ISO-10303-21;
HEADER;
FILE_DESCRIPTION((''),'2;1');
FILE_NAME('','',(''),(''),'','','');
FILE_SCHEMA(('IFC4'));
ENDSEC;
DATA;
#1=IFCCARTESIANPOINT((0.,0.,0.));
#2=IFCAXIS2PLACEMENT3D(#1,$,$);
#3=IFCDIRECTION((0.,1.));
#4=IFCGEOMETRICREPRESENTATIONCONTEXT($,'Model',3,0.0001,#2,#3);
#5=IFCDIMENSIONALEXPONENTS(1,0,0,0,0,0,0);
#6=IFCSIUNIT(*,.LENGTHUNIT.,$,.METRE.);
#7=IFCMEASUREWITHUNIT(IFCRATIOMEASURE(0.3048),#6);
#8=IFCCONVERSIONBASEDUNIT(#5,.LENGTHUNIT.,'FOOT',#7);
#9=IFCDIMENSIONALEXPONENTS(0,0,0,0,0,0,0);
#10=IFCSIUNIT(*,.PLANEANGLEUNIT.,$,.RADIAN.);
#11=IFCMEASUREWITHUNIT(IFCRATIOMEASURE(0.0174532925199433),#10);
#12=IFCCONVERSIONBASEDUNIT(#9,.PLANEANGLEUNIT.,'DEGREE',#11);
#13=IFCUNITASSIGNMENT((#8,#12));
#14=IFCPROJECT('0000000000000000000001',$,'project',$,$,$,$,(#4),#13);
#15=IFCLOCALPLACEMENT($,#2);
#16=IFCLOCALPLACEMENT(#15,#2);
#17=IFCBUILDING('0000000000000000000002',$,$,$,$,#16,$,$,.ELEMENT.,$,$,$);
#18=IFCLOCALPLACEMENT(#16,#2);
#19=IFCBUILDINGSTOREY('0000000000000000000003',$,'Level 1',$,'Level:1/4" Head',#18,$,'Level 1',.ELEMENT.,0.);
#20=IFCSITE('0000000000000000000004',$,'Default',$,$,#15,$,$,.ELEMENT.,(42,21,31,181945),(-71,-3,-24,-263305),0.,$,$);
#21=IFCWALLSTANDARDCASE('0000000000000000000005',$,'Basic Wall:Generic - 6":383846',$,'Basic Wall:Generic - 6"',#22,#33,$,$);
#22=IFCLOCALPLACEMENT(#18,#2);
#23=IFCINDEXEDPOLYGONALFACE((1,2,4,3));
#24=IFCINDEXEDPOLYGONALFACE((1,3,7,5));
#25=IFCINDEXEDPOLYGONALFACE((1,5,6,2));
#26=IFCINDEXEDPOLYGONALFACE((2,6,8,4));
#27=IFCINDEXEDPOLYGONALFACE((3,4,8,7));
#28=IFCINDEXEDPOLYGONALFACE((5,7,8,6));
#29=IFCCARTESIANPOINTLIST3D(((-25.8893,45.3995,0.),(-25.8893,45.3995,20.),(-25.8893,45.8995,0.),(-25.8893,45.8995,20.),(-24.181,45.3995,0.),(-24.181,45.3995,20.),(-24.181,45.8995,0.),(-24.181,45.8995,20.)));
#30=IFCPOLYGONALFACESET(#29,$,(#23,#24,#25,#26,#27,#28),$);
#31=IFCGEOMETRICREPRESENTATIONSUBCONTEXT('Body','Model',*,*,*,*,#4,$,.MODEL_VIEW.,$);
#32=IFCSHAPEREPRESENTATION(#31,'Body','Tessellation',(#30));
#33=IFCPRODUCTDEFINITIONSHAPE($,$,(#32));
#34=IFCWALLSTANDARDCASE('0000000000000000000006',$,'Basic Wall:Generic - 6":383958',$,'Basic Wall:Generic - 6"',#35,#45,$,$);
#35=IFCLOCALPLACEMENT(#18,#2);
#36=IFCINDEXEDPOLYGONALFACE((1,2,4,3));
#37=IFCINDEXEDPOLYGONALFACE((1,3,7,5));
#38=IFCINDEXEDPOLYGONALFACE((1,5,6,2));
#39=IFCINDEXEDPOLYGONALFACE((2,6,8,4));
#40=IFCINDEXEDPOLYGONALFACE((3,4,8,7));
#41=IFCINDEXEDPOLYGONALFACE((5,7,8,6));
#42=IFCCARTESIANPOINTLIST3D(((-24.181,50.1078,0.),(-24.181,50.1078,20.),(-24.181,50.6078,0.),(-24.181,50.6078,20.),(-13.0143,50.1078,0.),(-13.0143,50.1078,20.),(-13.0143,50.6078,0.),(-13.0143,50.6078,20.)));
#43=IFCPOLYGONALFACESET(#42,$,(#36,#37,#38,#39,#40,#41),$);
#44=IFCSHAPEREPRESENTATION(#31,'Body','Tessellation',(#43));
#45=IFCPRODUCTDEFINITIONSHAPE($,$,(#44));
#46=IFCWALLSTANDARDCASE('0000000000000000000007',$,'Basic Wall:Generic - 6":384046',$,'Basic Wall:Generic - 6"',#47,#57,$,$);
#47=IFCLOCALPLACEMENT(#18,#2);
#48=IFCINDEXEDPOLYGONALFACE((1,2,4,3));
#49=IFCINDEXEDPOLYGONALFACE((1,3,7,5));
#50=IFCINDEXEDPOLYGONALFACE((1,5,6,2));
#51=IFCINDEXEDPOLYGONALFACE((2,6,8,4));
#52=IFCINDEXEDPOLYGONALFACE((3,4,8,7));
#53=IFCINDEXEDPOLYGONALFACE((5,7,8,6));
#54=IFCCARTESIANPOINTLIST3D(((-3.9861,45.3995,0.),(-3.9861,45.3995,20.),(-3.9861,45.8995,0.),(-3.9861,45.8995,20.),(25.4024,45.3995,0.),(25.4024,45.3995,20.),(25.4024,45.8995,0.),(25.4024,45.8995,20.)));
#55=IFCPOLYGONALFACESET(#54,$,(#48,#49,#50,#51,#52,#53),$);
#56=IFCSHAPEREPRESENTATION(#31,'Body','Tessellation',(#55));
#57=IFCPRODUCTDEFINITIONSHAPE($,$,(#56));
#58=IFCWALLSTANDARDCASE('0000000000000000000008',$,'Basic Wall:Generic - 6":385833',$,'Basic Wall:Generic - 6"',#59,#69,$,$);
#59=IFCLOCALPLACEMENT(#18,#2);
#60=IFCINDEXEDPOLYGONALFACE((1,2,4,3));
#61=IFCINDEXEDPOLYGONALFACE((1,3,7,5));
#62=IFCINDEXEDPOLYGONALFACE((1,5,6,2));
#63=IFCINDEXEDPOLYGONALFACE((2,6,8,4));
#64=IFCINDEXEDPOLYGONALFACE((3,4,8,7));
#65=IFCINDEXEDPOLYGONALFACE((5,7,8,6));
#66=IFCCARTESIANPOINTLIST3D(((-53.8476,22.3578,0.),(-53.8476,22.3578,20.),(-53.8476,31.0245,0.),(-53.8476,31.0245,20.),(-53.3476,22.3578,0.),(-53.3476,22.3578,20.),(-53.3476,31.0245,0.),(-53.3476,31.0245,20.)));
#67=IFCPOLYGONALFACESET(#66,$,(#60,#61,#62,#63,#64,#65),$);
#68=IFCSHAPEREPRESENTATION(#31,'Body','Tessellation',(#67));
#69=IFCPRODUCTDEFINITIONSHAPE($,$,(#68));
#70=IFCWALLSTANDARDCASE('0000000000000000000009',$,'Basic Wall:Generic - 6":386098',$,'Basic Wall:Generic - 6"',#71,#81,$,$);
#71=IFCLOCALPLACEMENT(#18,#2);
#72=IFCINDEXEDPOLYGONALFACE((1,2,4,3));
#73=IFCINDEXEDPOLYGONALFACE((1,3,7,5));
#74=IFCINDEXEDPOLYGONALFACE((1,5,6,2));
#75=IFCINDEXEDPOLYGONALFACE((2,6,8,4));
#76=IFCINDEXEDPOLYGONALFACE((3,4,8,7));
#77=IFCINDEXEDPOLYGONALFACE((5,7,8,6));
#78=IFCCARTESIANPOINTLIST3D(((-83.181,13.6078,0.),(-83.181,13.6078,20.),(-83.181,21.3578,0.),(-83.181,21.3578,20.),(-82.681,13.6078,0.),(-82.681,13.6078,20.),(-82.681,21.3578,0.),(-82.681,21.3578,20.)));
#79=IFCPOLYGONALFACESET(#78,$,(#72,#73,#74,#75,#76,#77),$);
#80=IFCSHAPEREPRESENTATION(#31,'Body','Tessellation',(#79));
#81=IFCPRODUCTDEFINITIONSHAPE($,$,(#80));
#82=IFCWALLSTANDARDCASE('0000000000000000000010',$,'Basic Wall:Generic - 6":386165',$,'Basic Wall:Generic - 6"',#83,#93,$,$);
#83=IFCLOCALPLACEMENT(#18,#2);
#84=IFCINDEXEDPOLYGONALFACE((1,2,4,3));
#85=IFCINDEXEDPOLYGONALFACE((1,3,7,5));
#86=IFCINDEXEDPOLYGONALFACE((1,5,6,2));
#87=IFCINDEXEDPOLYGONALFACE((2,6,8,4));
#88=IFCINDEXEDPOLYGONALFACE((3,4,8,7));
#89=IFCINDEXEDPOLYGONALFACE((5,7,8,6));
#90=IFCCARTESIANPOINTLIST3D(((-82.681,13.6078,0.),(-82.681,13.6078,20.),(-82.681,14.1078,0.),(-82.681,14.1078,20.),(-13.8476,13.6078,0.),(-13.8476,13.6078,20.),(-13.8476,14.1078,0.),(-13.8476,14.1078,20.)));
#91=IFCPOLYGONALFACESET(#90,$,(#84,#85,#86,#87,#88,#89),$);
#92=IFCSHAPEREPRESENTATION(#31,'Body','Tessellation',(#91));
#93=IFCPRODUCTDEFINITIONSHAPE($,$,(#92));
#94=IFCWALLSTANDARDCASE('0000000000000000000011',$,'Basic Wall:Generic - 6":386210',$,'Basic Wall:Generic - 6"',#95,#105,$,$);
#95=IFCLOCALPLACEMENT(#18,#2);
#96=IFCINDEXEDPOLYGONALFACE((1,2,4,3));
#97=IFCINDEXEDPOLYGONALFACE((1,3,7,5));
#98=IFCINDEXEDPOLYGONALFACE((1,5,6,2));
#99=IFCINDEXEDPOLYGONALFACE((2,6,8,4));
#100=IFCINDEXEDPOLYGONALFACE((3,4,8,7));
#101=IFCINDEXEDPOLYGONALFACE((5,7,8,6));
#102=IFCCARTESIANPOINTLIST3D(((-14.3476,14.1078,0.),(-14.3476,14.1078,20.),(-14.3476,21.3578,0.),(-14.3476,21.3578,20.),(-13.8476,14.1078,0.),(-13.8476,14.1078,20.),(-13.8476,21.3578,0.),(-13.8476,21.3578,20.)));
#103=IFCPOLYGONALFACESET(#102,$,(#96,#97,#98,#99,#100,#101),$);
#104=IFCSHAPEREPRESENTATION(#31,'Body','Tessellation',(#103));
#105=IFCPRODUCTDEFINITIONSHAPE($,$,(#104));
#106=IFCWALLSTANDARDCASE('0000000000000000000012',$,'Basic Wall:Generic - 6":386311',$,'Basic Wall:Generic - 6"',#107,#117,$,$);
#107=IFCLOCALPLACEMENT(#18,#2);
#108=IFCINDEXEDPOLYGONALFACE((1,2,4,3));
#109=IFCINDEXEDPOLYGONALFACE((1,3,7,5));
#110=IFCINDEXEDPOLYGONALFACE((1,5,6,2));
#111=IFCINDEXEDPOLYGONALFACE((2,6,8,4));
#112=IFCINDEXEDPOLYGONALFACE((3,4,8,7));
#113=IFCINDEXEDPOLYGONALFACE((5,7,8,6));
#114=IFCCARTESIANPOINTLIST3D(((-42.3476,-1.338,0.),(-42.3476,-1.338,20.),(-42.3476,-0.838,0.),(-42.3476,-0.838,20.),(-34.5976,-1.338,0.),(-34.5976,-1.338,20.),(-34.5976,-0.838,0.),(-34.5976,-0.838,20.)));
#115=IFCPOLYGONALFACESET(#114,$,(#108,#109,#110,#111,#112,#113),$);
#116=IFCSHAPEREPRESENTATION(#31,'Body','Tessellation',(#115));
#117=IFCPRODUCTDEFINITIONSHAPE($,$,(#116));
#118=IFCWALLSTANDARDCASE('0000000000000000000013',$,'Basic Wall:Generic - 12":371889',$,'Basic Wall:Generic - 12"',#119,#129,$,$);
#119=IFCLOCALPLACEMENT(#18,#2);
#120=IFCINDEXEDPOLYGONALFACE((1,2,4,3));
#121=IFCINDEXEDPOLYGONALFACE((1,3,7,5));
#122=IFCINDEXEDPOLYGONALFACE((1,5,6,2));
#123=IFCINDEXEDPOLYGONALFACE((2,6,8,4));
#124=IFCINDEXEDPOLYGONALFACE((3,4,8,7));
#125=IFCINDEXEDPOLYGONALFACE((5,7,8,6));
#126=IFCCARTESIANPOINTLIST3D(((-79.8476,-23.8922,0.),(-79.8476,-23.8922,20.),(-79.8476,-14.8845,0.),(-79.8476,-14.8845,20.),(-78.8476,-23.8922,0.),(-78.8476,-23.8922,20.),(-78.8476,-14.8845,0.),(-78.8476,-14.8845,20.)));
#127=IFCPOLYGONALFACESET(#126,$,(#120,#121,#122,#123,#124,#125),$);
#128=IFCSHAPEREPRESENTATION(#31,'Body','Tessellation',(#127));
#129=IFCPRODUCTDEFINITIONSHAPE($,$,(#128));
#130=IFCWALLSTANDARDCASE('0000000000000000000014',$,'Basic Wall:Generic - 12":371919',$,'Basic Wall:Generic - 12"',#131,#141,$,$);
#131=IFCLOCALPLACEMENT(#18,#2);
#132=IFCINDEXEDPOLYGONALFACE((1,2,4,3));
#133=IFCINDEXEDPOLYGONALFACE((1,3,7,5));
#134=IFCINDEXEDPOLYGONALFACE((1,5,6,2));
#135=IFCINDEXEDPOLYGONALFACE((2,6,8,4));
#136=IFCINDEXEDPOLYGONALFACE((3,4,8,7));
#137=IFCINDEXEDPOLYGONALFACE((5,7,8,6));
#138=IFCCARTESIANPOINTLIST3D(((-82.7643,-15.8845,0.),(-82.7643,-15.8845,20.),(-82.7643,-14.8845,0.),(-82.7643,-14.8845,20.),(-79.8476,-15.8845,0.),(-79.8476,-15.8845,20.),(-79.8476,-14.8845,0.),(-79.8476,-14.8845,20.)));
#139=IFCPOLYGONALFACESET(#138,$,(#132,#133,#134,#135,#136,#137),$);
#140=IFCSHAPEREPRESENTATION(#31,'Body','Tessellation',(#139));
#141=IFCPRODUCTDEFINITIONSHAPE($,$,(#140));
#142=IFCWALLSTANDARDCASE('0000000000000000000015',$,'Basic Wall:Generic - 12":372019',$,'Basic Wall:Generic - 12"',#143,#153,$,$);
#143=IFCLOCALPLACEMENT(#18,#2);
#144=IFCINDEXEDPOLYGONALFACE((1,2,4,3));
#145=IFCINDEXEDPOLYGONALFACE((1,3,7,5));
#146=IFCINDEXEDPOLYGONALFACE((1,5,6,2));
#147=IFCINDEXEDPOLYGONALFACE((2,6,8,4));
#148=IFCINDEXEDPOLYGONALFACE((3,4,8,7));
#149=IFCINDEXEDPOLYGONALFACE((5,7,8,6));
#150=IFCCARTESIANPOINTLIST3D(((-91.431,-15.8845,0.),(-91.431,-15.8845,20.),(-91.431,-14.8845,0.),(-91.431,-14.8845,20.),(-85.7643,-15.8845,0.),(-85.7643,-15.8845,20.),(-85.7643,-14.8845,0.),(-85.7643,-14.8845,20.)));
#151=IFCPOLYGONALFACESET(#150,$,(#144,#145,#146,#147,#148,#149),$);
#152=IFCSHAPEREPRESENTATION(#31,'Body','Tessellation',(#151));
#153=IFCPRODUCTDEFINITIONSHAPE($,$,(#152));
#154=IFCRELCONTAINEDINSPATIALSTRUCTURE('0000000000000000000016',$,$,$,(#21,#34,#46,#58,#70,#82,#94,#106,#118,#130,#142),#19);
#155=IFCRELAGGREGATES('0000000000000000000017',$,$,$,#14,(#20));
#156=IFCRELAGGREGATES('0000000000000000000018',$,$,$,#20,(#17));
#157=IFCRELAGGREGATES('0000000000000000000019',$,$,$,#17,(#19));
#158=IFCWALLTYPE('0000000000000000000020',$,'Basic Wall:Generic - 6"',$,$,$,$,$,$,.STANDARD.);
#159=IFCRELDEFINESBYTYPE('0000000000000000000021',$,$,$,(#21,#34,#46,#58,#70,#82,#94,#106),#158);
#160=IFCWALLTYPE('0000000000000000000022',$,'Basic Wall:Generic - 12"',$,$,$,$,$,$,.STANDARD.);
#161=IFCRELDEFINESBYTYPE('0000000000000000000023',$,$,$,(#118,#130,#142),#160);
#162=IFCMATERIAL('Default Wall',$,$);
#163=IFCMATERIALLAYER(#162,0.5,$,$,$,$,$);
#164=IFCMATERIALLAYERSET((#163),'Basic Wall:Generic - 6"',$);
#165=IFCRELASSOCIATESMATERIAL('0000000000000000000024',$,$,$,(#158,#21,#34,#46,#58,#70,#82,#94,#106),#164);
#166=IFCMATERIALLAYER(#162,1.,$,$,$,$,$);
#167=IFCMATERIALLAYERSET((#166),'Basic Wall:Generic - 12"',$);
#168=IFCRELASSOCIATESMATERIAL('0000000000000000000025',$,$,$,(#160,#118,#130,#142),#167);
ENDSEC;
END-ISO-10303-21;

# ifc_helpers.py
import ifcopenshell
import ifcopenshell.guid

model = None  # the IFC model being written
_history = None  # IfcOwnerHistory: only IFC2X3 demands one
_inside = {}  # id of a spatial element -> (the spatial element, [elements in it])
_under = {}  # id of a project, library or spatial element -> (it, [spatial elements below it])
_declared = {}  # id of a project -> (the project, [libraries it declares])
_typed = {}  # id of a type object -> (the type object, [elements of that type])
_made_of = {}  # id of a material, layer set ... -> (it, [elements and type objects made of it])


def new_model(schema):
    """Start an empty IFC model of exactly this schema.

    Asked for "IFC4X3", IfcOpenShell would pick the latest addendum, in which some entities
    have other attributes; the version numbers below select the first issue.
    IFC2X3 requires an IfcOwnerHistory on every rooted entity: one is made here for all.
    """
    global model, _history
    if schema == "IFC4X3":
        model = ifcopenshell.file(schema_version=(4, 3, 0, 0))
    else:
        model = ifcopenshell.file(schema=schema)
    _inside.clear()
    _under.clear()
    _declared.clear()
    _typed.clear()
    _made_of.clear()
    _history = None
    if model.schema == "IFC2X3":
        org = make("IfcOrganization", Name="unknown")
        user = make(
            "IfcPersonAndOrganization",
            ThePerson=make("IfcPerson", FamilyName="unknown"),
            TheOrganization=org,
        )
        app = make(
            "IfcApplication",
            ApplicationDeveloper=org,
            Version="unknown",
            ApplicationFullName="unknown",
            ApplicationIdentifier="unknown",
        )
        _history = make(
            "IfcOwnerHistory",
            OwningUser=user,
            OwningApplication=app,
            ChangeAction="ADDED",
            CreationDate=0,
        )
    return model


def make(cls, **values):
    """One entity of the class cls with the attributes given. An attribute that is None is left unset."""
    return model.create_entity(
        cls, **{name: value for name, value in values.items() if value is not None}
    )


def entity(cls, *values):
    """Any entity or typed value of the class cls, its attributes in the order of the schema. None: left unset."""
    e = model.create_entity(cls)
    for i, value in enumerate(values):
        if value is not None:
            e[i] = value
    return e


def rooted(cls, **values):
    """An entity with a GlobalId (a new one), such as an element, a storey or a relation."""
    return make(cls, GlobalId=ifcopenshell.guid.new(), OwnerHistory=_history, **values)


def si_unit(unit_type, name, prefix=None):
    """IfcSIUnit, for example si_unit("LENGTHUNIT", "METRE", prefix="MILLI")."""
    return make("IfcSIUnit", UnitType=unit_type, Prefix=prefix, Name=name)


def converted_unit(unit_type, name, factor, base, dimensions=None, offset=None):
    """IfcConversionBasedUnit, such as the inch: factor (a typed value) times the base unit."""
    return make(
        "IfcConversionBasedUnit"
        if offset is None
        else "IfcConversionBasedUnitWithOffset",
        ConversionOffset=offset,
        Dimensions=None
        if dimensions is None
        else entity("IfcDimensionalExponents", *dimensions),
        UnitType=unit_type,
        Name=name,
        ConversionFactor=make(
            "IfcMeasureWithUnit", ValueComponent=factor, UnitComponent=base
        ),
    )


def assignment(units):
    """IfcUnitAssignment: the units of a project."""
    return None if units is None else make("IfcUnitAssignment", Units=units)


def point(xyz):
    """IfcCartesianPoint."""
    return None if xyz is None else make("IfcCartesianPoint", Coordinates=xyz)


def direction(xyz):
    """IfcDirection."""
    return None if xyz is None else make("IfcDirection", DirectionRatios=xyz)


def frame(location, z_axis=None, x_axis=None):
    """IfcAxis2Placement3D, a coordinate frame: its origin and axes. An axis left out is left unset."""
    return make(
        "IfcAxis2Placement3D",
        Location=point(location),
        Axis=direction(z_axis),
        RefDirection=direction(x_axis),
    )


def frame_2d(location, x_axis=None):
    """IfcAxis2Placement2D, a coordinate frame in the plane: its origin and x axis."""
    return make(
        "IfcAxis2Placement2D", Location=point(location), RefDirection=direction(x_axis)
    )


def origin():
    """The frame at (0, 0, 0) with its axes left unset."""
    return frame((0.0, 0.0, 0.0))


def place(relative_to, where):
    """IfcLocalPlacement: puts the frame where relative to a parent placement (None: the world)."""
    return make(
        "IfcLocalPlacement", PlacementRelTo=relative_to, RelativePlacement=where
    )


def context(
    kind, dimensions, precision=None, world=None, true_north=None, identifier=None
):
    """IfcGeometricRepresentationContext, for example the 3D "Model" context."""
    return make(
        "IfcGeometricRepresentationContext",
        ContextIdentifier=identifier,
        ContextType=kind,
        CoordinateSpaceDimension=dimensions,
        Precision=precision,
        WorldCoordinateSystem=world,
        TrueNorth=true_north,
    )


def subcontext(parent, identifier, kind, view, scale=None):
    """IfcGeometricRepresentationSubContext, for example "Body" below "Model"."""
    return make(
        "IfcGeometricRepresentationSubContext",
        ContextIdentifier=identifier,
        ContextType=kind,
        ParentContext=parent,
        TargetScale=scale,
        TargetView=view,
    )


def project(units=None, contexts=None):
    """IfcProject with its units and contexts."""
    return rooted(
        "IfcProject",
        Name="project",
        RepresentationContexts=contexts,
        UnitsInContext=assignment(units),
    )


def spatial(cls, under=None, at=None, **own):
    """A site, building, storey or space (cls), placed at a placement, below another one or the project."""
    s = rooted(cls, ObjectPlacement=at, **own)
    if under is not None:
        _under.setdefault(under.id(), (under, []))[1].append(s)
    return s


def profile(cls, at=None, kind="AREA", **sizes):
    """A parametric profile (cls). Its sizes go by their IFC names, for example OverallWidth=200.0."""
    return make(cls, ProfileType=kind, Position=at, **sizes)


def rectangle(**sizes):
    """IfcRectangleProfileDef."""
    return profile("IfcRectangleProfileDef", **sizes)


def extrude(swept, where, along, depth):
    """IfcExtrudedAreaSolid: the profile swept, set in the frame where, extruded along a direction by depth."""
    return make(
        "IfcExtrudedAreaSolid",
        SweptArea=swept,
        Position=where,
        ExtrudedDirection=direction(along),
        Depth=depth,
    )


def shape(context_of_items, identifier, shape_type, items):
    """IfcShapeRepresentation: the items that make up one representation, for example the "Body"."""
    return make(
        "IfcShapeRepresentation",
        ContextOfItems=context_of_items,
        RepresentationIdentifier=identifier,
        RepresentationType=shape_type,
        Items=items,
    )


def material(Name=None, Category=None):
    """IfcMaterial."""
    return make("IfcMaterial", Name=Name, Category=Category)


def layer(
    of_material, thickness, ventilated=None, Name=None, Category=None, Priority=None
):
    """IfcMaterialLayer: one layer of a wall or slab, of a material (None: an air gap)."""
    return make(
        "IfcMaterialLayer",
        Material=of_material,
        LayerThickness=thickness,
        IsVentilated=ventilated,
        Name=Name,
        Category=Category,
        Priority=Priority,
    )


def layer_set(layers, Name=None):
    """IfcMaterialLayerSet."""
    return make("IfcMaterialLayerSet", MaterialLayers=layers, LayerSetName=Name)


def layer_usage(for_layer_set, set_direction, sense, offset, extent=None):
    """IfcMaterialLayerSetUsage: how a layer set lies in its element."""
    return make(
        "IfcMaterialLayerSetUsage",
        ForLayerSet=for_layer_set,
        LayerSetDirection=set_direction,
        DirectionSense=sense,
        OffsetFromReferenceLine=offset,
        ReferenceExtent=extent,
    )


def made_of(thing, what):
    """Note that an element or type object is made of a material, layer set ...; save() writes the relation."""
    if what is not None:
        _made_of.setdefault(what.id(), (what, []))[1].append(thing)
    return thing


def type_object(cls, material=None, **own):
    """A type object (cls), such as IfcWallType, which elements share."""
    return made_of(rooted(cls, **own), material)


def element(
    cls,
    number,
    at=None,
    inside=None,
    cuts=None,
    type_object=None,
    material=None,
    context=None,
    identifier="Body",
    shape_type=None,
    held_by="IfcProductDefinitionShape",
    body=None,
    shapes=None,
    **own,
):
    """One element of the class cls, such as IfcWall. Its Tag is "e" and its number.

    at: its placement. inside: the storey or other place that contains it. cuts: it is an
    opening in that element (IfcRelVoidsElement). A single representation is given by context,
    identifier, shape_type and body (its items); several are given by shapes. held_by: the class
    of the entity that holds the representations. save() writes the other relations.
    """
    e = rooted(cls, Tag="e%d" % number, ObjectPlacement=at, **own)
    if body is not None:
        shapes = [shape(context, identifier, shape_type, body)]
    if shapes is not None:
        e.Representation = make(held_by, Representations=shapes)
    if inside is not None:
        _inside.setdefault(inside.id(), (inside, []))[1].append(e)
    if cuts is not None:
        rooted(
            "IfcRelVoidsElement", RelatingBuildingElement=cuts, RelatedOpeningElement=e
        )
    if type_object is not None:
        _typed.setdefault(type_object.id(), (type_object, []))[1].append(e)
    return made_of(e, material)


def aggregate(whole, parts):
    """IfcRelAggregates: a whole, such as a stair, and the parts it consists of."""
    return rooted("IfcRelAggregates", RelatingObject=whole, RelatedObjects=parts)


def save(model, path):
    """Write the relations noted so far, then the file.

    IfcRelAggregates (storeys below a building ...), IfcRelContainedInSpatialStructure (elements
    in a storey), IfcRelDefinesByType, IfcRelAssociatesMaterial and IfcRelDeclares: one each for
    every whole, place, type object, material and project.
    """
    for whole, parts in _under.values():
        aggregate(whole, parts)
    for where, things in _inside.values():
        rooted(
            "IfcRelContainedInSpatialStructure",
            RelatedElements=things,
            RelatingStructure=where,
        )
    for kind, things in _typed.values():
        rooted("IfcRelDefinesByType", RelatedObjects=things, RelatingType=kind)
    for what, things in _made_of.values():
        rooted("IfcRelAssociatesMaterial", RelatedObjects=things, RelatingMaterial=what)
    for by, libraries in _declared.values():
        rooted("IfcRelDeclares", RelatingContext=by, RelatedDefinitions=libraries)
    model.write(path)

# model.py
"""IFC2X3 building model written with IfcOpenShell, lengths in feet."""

from ifc_helpers import new_model, entity, si_unit, converted_unit, direction, frame, frame_2d, origin, place, context, subcontext, project, spatial, rectangle, extrude, material, layer, layer_set, layer_usage, type_object, element, save


model = new_model("IFC2X3")

# Units and contexts
model_context = context("Model", 3, precision=0.0001, world=origin(), true_north=direction((0.0, 1.0)))
body_context = subcontext(model_context, "Body", "Model", "MODEL_VIEW")
ifc_project = project(units=[converted_unit("LENGTHUNIT", "FOOT", entity("IfcRatioMeasure", 0.3048), si_unit("LENGTHUNIT", "METRE"), dimensions=[1, 0, 0, 0, 0, 0, 0]), converted_unit("PLANEANGLEUNIT", "DEGREE", entity("IfcRatioMeasure", 0.0174532925199433), si_unit("PLANEANGLEUNIT", "RADIAN"), dimensions=[0, 0, 0, 0, 0, 0, 0])], contexts=[model_context])

# Site, building, storey
site_placement = place(None, origin())
site = spatial("IfcSite", under=ifc_project, at=site_placement, Name="Default", CompositionType="ELEMENT", RefLatitude=(42, 21, 31, 181945), RefLongitude=(-71, -3, -24, -263305), RefElevation=0.0)
building_placement = place(site_placement, origin())
building = spatial("IfcBuilding", under=site, at=building_placement, CompositionType="ELEMENT")
storey_placement = place(building_placement, origin())
storey = spatial("IfcBuildingStorey", under=building, at=storey_placement, Name="Level 1", ObjectType="Level:1/4\" Head", LongName="Level 1", CompositionType="ELEMENT", Elevation=0.0)

# Walls
ifc_material = material(Name="Default Wall")
ifc_layer_1 = layer(ifc_material, 0.5)
ifc_layer_set_1 = layer_set([ifc_layer_1], Name="Basic Wall:Generic - 6\"")
wall_type_1 = type_object("IfcWallType", Name="Basic Wall:Generic - 6\"", PredefinedType="STANDARD", material=ifc_layer_set_1)
ifc_layer_usage_1 = layer_usage(ifc_layer_set_1, "AXIS2", "NEGATIVE", 0.25)
wall_1_placement = place(storey_placement, frame((-25.8893, 45.6495, 0.0)))
element("IfcWallStandardCase", 1, at=wall_1_placement, inside=storey, type_object=wall_type_1, material=ifc_layer_usage_1, Name="Basic Wall:Generic - 6\":383846", ObjectType="Basic Wall:Generic - 6\"", context=body_context, shape_type="SweptSolid", body=[
    extrude(rectangle(XDim=1.7083, YDim=0.5, at=frame_2d((0.8542, 0.0), x_axis=(-1.0, 0.0))), origin(), (0.0, 0.0, 1.0), 20.0),
])
ifc_layer_usage_2 = layer_usage(ifc_layer_set_1, "AXIS2", "NEGATIVE", 0.25)
wall_2_placement = place(storey_placement, frame((-24.181, 50.3578, 0.0)))
element("IfcWallStandardCase", 2, at=wall_2_placement, inside=storey, type_object=wall_type_1, material=ifc_layer_usage_2, Name="Basic Wall:Generic - 6\":383958", ObjectType="Basic Wall:Generic - 6\"", context=body_context, shape_type="SweptSolid", body=[
    extrude(rectangle(XDim=11.1667, YDim=0.5, at=frame_2d((5.5833, 0.0), x_axis=(-1.0, 0.0))), origin(), (0.0, 0.0, 1.0), 20.0),
])
ifc_layer_usage_3 = layer_usage(ifc_layer_set_1, "AXIS2", "NEGATIVE", 0.25)
wall_3_placement = place(storey_placement, frame((-3.9861, 45.6495, 0.0)))
element("IfcWallStandardCase", 3, at=wall_3_placement, inside=storey, type_object=wall_type_1, material=ifc_layer_usage_3, Name="Basic Wall:Generic - 6\":384046", ObjectType="Basic Wall:Generic - 6\"", context=body_context, shape_type="SweptSolid", body=[
    extrude(rectangle(XDim=29.3884, YDim=0.5, at=frame_2d((14.6942, 0.0), x_axis=(-1.0, 0.0))), origin(), (0.0, 0.0, 1.0), 20.0),
])
ifc_layer_usage_4 = layer_usage(ifc_layer_set_1, "AXIS2", "NEGATIVE", 0.25)
wall_4_placement = place(storey_placement, frame((-53.5976, 31.0245, 0.0), z_axis=(0.0, 0.0, 1.0), x_axis=(0.0, -1.0, 0.0)))
element("IfcWallStandardCase", 4, at=wall_4_placement, inside=storey, type_object=wall_type_1, material=ifc_layer_usage_4, Name="Basic Wall:Generic - 6\":385833", ObjectType="Basic Wall:Generic - 6\"", context=body_context, shape_type="SweptSolid", body=[
    extrude(rectangle(XDim=8.6667, YDim=0.5, at=frame_2d((4.3333, 0.0), x_axis=(-1.0, 0.0))), origin(), (0.0, 0.0, 1.0), 20.0),
])
ifc_layer_usage_5 = layer_usage(ifc_layer_set_1, "AXIS2", "NEGATIVE", 0.25)
wall_5_placement = place(storey_placement, frame((-82.931, 21.3578, 0.0), z_axis=(0.0, 0.0, 1.0), x_axis=(0.0, -1.0, 0.0)))
element("IfcWallStandardCase", 5, at=wall_5_placement, inside=storey, type_object=wall_type_1, material=ifc_layer_usage_5, Name="Basic Wall:Generic - 6\":386098", ObjectType="Basic Wall:Generic - 6\"", context=body_context, shape_type="SweptSolid", body=[
    extrude(rectangle(XDim=7.75, YDim=0.5, at=frame_2d((3.875, 0.0), x_axis=(-1.0, 0.0))), origin(), (0.0, 0.0, 1.0), 20.0),
])
ifc_layer_usage_6 = layer_usage(ifc_layer_set_1, "AXIS2", "NEGATIVE", 0.25)
wall_6_placement = place(storey_placement, frame((-82.681, 13.8578, 0.0)))
element("IfcWallStandardCase", 6, at=wall_6_placement, inside=storey, type_object=wall_type_1, material=ifc_layer_usage_6, Name="Basic Wall:Generic - 6\":386165", ObjectType="Basic Wall:Generic - 6\"", context=body_context, shape_type="SweptSolid", body=[
    extrude(rectangle(XDim=68.8333, YDim=0.5, at=frame_2d((34.4167, 0.0), x_axis=(-1.0, 0.0))), origin(), (0.0, 0.0, 1.0), 20.0),
])
ifc_layer_usage_7 = layer_usage(ifc_layer_set_1, "AXIS2", "NEGATIVE", 0.25)
wall_7_placement = place(storey_placement, frame((-14.0976, 14.1078, 0.0), z_axis=(0.0, 0.0, 1.0), x_axis=(0.0, 1.0, 0.0)))
element("IfcWallStandardCase", 7, at=wall_7_placement, inside=storey, type_object=wall_type_1, material=ifc_layer_usage_7, Name="Basic Wall:Generic - 6\":386210", ObjectType="Basic Wall:Generic - 6\"", context=body_context, shape_type="SweptSolid", body=[
    extrude(rectangle(XDim=7.25, YDim=0.5, at=frame_2d((3.625, 0.0), x_axis=(-1.0, 0.0))), origin(), (0.0, 0.0, 1.0), 20.0),
])
ifc_layer_usage_8 = layer_usage(ifc_layer_set_1, "AXIS2", "NEGATIVE", 0.25)
wall_8_placement = place(storey_placement, frame((-42.3476, -1.088, 0.0)))
element("IfcWallStandardCase", 8, at=wall_8_placement, inside=storey, type_object=wall_type_1, material=ifc_layer_usage_8, Name="Basic Wall:Generic - 6\":386311", ObjectType="Basic Wall:Generic - 6\"", context=body_context, shape_type="SweptSolid", body=[
    extrude(rectangle(XDim=7.75, YDim=0.5, at=frame_2d((3.875, 0.0), x_axis=(-1.0, 0.0))), origin(), (0.0, 0.0, 1.0), 20.0),
])
ifc_layer_2 = layer(ifc_material, 1.0)
ifc_layer_set_2 = layer_set([ifc_layer_2], Name="Basic Wall:Generic - 12\"")
ifc_layer_usage_9 = layer_usage(ifc_layer_set_2, "AXIS2", "NEGATIVE", 0.5)
wall_type_2 = type_object("IfcWallType", Name="Basic Wall:Generic - 12\"", PredefinedType="STANDARD", material=ifc_layer_set_2)
wall_9_placement = place(storey_placement, frame((-79.3476, -23.8922, 0.0), z_axis=(0.0, 0.0, 1.0), x_axis=(0.0, 1.0, 0.0)))
element("IfcWallStandardCase", 9, at=wall_9_placement, inside=storey, type_object=wall_type_2, material=ifc_layer_usage_9, Name="Basic Wall:Generic - 12\":371889", ObjectType="Basic Wall:Generic - 12\"", context=body_context, shape_type="SweptSolid", body=[
    extrude(rectangle(XDim=9.0076, YDim=1.0, at=frame_2d((4.5038, 0.0), x_axis=(-1.0, 0.0))), origin(), (0.0, 0.0, 1.0), 20.0),
])
ifc_layer_usage_10 = layer_usage(ifc_layer_set_2, "AXIS2", "NEGATIVE", 0.5)
wall_10_placement = place(storey_placement, frame((-79.8476, -15.3845, 0.0), z_axis=(0.0, 0.0, 1.0), x_axis=(-1.0, 0.0, 0.0)))
element("IfcWallStandardCase", 10, at=wall_10_placement, inside=storey, type_object=wall_type_2, material=ifc_layer_usage_10, Name="Basic Wall:Generic - 12\":371919", ObjectType="Basic Wall:Generic - 12\"", context=body_context, shape_type="SweptSolid", body=[
    extrude(rectangle(XDim=2.9167, YDim=1.0, at=frame_2d((1.4583, 0.0), x_axis=(-1.0, 0.0))), origin(), (0.0, 0.0, 1.0), 20.0),
])
ifc_layer_usage_11 = layer_usage(ifc_layer_set_2, "AXIS2", "NEGATIVE", 0.5)
wall_11_placement = place(storey_placement, frame((-85.7643, -15.3845, 0.0), z_axis=(0.0, 0.0, 1.0), x_axis=(-1.0, 0.0, 0.0)))
element("IfcWallStandardCase", 11, at=wall_11_placement, inside=storey, type_object=wall_type_2, material=ifc_layer_usage_11, Name="Basic Wall:Generic - 12\":372019", ObjectType="Basic Wall:Generic - 12\"", context=body_context, shape_type="SweptSolid", body=[
    extrude(rectangle(XDim=5.6667, YDim=1.0, at=frame_2d((2.8333, 0.0), x_axis=(-1.0, 0.0))), origin(), (0.0, 0.0, 1.0), 20.0),
])

save(model, "model.ifc")
